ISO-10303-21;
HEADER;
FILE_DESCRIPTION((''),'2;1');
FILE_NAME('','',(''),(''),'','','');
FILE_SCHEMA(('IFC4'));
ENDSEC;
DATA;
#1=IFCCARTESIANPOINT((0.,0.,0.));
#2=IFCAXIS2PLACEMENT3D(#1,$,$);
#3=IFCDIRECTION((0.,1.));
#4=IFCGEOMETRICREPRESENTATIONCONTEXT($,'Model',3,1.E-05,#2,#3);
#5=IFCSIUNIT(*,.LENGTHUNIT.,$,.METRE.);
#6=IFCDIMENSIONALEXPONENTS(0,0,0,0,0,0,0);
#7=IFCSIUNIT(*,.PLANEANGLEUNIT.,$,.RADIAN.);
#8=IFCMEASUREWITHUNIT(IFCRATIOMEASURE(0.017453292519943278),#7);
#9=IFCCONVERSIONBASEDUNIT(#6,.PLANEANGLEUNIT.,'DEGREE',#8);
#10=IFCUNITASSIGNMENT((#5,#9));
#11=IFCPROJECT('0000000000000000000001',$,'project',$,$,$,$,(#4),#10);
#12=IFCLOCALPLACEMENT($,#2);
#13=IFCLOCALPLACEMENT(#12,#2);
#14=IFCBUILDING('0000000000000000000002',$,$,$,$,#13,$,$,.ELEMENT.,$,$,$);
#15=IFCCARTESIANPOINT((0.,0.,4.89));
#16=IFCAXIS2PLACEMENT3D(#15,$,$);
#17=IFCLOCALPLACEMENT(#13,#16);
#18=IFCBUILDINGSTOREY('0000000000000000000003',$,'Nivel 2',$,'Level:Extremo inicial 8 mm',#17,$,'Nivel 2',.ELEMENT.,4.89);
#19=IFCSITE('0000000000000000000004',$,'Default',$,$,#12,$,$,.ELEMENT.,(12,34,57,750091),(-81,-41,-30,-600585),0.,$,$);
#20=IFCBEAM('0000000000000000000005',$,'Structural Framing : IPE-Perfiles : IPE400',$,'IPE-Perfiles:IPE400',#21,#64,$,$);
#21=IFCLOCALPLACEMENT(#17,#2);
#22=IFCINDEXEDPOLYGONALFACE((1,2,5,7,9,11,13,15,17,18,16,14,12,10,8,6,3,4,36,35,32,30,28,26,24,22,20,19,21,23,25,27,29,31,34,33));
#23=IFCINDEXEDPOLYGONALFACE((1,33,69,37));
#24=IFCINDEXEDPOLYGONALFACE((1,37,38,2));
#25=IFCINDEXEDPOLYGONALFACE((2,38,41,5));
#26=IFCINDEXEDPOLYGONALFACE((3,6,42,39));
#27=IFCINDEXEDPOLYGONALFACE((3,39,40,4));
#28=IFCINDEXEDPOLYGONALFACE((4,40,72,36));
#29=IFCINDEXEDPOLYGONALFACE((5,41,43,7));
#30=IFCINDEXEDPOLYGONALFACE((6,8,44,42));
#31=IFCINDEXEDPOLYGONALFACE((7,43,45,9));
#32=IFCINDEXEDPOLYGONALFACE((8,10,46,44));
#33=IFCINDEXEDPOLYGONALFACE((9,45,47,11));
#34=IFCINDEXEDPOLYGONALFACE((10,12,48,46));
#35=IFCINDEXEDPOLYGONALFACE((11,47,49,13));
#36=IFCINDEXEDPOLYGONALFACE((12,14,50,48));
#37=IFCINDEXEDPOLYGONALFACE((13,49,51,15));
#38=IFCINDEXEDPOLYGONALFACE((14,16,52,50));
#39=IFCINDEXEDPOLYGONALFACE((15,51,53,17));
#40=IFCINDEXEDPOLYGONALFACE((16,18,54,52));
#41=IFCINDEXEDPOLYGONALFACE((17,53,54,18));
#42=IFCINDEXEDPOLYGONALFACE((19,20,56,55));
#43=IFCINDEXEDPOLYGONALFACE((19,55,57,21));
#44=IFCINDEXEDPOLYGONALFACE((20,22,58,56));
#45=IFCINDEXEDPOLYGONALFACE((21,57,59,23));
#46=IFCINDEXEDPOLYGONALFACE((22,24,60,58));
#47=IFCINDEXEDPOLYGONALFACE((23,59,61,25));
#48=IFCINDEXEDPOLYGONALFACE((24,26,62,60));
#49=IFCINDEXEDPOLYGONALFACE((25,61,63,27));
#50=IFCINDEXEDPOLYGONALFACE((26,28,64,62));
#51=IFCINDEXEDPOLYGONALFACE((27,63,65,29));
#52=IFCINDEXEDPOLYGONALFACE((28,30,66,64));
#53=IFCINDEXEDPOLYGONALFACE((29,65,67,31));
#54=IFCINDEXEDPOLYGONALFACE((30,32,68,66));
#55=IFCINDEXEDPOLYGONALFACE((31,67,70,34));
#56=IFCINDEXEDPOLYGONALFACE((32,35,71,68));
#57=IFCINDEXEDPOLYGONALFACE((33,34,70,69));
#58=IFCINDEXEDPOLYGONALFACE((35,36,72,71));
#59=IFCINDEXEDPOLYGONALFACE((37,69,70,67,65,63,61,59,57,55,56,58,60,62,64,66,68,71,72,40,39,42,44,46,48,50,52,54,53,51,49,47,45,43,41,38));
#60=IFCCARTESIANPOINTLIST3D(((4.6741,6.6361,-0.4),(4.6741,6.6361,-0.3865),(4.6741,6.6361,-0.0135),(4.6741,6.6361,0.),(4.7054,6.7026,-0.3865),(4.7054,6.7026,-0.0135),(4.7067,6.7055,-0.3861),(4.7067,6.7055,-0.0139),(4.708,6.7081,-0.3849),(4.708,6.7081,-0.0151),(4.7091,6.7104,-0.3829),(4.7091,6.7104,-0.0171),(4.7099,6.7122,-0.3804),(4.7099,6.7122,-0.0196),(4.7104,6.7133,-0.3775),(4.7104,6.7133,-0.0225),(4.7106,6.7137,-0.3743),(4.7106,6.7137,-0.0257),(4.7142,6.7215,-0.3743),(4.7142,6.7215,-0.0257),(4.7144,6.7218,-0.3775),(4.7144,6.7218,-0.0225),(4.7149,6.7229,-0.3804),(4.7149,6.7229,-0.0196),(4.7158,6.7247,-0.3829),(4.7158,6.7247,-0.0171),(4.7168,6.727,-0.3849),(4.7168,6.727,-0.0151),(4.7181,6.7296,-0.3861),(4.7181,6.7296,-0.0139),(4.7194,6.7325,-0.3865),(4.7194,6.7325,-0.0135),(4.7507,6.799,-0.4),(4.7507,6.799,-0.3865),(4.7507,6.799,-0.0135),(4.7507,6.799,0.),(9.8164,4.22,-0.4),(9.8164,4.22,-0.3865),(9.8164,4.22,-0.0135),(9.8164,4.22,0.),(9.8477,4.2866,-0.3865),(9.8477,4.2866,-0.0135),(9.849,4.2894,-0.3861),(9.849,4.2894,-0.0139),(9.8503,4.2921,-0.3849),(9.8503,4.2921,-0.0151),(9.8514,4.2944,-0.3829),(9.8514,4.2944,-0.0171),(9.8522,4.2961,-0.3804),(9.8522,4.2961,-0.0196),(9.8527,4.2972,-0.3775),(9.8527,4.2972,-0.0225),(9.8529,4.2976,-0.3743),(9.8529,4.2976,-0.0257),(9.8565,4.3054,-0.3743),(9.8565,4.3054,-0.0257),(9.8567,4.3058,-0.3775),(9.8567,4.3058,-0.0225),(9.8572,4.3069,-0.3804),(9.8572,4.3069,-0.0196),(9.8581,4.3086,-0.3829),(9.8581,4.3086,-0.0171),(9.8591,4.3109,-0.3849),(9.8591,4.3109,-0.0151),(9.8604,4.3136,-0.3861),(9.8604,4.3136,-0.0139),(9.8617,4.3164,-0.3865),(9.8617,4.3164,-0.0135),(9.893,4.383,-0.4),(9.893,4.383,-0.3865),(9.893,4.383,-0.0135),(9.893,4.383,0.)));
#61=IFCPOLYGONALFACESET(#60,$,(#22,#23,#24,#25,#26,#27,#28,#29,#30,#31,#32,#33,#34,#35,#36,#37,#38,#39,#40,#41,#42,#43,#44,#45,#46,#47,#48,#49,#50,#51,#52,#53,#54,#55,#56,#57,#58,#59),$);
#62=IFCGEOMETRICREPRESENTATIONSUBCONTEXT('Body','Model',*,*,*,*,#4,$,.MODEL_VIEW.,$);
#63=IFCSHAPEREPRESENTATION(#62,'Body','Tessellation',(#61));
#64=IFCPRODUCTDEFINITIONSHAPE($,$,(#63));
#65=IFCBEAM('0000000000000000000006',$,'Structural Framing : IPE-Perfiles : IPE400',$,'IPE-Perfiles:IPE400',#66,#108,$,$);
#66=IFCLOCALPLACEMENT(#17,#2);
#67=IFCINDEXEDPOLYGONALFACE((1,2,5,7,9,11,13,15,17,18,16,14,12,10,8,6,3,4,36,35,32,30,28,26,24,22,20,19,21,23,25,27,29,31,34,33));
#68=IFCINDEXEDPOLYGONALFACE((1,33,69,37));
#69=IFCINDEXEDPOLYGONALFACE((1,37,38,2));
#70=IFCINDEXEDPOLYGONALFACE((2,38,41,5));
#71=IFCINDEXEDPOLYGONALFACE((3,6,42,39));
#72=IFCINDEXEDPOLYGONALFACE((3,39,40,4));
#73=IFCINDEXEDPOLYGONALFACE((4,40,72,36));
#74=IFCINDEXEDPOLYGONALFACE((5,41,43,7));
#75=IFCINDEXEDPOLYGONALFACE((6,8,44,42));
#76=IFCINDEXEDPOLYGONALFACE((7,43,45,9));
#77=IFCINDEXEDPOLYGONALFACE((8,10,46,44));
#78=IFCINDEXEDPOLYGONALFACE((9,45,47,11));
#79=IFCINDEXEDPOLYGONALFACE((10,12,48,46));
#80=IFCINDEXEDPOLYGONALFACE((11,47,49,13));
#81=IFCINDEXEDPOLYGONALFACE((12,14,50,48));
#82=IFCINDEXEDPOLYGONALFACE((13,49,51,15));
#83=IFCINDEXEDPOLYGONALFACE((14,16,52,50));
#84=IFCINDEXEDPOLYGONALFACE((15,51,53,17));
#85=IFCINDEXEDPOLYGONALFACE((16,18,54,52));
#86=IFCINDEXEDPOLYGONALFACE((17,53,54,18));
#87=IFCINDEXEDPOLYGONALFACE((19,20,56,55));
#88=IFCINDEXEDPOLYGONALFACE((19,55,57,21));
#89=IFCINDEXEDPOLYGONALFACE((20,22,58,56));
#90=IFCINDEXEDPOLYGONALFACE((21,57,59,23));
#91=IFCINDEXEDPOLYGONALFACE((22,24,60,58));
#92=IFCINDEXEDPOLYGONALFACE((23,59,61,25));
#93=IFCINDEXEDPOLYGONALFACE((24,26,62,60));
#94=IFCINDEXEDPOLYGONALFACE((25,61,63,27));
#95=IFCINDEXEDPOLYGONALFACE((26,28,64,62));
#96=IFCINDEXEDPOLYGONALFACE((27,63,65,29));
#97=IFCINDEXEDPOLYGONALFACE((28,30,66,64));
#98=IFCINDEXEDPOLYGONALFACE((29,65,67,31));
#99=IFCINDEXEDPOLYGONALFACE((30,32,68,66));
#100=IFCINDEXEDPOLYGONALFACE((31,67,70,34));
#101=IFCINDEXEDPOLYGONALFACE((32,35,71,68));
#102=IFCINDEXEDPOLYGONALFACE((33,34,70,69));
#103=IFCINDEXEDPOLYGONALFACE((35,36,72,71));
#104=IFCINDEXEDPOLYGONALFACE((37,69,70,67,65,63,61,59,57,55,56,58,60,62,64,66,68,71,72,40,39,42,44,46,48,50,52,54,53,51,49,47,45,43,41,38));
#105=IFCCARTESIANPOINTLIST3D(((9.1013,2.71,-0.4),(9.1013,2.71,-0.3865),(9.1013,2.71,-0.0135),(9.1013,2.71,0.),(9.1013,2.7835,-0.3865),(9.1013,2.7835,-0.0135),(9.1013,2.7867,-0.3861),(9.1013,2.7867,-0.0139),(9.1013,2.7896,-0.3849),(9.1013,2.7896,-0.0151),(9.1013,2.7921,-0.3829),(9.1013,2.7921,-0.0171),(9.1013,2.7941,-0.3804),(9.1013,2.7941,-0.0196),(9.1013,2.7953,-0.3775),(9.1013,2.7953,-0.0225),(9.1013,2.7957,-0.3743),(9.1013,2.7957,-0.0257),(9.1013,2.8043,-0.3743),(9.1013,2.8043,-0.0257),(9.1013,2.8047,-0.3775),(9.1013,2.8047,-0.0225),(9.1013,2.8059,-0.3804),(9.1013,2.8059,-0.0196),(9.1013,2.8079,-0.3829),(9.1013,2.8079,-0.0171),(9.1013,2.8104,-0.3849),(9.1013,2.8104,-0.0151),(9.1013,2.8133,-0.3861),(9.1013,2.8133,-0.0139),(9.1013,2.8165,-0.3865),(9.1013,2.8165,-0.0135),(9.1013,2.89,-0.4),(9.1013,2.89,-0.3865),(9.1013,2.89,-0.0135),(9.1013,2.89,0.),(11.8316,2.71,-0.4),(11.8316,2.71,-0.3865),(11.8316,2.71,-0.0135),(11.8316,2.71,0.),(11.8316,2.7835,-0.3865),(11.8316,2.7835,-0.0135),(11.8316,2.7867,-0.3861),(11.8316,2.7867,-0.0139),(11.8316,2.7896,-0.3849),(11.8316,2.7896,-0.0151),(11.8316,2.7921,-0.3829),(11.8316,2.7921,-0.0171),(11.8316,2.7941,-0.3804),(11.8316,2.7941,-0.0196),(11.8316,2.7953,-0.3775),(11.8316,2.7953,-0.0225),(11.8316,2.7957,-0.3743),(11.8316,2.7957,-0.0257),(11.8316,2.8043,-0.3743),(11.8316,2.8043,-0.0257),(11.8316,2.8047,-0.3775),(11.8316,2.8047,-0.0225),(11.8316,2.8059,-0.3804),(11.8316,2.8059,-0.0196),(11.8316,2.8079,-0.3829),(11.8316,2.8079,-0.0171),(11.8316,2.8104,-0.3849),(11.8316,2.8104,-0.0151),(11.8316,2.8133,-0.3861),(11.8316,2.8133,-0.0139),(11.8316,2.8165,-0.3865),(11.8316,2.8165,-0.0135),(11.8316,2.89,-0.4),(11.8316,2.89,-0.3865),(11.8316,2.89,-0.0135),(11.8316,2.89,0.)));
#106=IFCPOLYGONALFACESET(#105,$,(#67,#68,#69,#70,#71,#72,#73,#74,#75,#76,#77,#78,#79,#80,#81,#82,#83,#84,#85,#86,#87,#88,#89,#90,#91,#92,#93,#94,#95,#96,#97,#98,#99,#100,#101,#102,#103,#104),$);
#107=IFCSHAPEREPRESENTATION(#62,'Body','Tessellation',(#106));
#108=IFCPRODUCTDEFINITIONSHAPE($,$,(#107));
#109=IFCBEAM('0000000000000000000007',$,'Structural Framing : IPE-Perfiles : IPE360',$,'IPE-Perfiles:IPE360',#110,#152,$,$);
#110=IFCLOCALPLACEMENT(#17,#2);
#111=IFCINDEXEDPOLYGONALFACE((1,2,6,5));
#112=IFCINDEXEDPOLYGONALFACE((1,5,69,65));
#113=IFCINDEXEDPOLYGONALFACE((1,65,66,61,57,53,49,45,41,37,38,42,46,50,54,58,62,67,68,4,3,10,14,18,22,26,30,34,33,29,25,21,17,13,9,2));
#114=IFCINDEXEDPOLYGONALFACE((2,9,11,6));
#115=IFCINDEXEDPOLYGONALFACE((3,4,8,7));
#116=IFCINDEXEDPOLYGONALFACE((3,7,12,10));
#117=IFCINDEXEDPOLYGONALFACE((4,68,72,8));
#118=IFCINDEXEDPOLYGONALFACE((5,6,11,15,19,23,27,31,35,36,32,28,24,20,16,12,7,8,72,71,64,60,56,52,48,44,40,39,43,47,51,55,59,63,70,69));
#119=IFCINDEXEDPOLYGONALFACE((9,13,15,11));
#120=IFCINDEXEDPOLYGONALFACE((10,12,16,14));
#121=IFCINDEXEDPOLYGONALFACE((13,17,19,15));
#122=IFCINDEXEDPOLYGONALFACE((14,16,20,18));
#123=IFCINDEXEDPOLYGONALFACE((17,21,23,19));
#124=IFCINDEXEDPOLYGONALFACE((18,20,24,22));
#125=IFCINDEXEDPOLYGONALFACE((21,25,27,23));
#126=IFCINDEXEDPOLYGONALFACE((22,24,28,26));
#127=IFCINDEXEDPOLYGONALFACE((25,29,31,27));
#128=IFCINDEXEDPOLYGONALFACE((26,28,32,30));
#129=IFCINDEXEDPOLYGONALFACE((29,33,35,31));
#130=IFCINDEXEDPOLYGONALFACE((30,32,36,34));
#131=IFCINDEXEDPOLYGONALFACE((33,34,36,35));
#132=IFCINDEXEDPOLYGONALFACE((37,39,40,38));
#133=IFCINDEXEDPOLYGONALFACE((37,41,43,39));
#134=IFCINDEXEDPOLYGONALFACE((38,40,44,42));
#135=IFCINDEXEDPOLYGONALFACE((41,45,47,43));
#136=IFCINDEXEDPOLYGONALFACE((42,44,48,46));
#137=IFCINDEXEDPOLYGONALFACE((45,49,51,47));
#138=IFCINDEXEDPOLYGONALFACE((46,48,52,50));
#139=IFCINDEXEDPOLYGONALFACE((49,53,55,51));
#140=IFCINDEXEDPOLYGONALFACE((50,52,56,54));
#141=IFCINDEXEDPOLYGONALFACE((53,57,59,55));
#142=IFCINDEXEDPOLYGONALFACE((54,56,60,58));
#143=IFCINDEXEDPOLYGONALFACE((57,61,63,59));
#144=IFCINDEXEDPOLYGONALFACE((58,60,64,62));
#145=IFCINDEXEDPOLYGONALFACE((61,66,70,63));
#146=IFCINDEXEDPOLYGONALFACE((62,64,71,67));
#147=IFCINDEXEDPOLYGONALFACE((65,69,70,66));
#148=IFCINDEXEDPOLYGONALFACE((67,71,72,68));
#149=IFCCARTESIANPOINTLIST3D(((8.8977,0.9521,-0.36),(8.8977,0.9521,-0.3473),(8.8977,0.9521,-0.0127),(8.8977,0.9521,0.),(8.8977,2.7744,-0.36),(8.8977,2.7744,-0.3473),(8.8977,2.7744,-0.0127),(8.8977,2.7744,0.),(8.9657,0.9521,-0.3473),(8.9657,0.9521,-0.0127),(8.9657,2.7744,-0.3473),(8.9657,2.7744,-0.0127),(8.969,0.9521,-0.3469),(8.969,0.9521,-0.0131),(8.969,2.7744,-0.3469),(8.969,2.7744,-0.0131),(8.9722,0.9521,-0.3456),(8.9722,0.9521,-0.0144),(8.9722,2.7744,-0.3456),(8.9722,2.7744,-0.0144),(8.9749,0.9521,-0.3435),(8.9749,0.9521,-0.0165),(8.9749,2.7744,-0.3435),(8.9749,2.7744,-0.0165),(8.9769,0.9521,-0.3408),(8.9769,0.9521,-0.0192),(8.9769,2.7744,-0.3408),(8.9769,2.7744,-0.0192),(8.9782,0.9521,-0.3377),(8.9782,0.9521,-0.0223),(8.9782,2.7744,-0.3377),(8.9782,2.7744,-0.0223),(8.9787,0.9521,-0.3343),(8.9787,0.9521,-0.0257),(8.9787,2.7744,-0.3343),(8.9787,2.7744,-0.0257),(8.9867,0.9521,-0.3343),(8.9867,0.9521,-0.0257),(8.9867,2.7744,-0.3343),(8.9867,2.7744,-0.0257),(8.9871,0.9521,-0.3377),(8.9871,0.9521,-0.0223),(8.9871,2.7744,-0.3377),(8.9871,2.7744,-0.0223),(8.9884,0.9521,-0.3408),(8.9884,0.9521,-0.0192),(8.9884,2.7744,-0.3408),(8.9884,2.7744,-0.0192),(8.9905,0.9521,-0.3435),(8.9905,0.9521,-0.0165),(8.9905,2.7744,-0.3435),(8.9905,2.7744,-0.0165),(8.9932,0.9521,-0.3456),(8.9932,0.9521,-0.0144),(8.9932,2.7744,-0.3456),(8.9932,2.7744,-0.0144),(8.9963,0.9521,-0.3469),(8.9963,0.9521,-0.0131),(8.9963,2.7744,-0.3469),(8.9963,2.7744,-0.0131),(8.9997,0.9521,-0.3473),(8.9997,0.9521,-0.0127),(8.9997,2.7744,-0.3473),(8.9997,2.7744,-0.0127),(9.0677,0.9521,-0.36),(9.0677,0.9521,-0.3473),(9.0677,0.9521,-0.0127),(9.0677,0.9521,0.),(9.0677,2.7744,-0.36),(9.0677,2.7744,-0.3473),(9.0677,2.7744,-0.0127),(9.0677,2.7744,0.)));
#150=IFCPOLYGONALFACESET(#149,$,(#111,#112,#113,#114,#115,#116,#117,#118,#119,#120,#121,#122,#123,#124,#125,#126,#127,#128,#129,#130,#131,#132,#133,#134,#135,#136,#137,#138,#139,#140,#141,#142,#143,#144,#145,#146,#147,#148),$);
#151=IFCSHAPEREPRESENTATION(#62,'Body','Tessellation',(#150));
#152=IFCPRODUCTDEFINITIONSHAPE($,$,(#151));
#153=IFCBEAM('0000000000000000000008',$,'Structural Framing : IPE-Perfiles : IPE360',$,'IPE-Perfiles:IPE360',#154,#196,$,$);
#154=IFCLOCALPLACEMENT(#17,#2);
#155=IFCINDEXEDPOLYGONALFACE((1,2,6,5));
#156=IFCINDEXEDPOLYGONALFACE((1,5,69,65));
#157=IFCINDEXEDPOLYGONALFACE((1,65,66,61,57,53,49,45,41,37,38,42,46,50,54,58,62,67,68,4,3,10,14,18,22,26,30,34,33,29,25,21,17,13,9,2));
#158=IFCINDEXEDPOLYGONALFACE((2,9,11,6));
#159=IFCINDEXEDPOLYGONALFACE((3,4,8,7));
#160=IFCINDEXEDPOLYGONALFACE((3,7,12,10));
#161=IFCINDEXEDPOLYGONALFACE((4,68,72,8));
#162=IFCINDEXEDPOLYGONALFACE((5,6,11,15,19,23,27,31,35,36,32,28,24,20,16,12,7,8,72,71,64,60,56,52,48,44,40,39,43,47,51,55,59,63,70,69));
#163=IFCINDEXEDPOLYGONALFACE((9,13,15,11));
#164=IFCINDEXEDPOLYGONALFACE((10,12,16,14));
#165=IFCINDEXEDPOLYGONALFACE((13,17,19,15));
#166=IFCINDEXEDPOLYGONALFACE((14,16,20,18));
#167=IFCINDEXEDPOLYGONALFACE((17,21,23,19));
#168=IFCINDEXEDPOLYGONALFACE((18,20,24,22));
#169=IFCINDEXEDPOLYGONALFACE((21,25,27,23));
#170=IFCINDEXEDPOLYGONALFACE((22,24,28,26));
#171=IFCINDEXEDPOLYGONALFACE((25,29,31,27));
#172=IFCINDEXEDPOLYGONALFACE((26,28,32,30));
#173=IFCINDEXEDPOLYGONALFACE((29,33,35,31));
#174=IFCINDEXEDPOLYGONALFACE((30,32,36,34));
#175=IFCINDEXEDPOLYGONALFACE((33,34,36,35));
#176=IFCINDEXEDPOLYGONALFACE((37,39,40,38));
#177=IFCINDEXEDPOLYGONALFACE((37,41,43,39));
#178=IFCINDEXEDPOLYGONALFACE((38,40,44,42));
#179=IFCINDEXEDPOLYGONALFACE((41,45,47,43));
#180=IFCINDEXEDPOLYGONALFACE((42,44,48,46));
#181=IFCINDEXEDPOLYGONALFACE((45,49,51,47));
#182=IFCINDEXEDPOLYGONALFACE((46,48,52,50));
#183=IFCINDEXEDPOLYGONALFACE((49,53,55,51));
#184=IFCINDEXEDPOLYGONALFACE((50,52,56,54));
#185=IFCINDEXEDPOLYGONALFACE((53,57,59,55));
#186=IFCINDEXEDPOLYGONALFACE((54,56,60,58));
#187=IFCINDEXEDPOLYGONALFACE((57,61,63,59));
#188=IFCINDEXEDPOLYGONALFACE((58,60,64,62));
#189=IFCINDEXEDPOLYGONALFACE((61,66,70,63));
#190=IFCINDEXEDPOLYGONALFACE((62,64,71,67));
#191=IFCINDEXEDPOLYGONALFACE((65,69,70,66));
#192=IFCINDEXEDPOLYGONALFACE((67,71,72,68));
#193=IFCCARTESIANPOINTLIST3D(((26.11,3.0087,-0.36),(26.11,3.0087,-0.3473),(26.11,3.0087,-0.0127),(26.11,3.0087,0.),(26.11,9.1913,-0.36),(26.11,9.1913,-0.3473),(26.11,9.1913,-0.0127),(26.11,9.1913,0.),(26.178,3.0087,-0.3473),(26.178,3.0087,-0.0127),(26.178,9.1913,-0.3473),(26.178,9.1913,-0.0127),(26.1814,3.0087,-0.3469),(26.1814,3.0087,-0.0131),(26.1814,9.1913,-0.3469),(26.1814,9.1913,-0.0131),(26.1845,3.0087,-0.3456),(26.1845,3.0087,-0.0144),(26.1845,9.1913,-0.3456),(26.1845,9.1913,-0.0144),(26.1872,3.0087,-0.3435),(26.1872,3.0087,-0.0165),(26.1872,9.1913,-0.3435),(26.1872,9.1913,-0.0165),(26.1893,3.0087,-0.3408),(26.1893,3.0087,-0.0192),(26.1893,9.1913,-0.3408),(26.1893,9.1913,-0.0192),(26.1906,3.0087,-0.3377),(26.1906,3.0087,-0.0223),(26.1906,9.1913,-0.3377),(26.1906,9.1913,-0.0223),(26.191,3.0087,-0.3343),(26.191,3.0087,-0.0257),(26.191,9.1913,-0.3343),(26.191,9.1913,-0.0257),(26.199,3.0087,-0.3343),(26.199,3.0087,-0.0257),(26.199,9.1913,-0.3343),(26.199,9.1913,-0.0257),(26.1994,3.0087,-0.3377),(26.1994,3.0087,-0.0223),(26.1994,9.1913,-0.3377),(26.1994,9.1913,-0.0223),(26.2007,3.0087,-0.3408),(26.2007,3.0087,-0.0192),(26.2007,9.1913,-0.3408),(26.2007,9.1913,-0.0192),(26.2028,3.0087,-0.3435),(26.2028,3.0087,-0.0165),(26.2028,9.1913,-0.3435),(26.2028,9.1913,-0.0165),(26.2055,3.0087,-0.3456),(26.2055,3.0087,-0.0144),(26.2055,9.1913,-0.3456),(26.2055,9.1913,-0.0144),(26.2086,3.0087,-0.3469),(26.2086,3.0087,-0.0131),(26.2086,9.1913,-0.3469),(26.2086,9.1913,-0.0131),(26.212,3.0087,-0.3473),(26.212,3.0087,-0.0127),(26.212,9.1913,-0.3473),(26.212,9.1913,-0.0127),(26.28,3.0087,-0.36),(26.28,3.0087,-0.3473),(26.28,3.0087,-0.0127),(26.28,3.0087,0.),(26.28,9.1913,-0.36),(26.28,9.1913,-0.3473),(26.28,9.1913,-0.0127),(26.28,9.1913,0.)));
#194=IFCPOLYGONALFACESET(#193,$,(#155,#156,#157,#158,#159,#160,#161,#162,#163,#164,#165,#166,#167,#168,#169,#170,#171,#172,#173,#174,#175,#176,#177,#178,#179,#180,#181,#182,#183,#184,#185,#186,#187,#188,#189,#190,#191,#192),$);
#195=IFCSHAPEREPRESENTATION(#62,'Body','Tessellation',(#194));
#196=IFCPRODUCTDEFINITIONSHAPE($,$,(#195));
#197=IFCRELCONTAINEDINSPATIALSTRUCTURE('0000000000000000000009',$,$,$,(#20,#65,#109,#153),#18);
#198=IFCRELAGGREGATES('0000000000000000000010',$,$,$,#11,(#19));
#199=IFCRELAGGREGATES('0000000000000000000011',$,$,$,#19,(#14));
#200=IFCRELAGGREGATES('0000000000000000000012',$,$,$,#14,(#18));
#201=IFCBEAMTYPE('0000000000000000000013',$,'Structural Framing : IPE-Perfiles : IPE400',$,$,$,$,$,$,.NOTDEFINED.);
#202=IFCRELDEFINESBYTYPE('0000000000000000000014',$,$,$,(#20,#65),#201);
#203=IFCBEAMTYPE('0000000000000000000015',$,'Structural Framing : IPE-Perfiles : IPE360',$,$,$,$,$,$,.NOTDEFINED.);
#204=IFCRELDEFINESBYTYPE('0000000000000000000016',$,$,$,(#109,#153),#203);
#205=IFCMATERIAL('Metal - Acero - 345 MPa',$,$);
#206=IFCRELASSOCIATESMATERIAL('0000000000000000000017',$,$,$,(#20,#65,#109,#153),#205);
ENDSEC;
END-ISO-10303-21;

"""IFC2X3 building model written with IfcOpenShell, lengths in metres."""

from ifc_helpers import new_model, entity, si_unit, converted_unit, direction, frame, frame_2d, origin, place, context, subcontext, project, spatial, i_section, extrude, material, type_object, element, save


model = new_model("IFC2X3")

# Units and contexts
model_context = context("Model", 3, precision=1e-05, world=origin(), true_north=direction((0.0, 1.0)))
body_context = subcontext(model_context, "Body", "Model", "MODEL_VIEW")
ifc_project = project(units=[si_unit("LENGTHUNIT", "METRE"), converted_unit("PLANEANGLEUNIT", "DEGREE", entity("IfcRatioMeasure", 0.017453292519943278), si_unit("PLANEANGLEUNIT", "RADIAN"), dimensions=[0, 0, 0, 0, 0, 0, 0])], contexts=[model_context])

# Site, building, storey
site_placement = place(None, origin())
site = spatial("IfcSite", under=ifc_project, at=site_placement, Name="Default", CompositionType="ELEMENT", RefLatitude=(12, 34, 57, 750091), RefLongitude=(-81, -41, -30, -600585), RefElevation=0.0)
building_placement = place(site_placement, origin())
building = spatial("IfcBuilding", under=site, at=building_placement, CompositionType="ELEMENT")
storey_placement = place(building_placement, frame((0.0, 0.0, 4.89)))
storey = spatial("IfcBuildingStorey", under=building, at=storey_placement, Name="Nivel 2", ObjectType="Level:Extremo inicial 8 mm", LongName="Nivel 2", CompositionType="ELEMENT", Elevation=4.89)

# Shared definitions
ifc_material_1 = material(Name="Metal - Acero - 345 MPa")

# Beams
beam_type_1 = type_object("IfcBeamType", Name="Structural Framing : IPE-Perfiles : IPE400", PredefinedType="NOTDEFINED")
beam_1_placement = place(storey_placement, frame((9.8671, 4.2957, 0.0), z_axis=(0.0, 0.0, 1.0), x_axis=(-0.905079, 0.425243, 0.0)))
element("IfcBeam", 1, at=beam_1_placement, inside=storey, type_object=beam_type_1, material=ifc_material_1, Name="Structural Framing : IPE-Perfiles : IPE400", ObjectType="IPE-Perfiles:IPE400", context=body_context, shape_type="SweptSolid", body=[
    extrude(i_section(OverallWidth=0.18, OverallDepth=0.4, WebThickness=0.0086, FlangeThickness=0.0135, FilletRadius=0.0122, at=frame_2d((0.0, 0.0), x_axis=(0.0, 1.0))), frame((0.0137, 0.0, -0.2), z_axis=(1.0, 0.0, 0.0), x_axis=(0.0, 0.0, -1.0)), (0.0, 0.0, 1.0), 5.6816),
])
beam_2_placement = place(storey_placement, frame((9.0882, 2.8, 0.0)))
element("IfcBeam", 2, at=beam_2_placement, inside=storey, type_object=beam_type_1, material=ifc_material_1, Name="Structural Framing : IPE-Perfiles : IPE400", ObjectType="IPE-Perfiles:IPE400", context=body_context, shape_type="SweptSolid", body=[
    extrude(i_section(OverallWidth=0.18, OverallDepth=0.4, WebThickness=0.0086, FlangeThickness=0.0135, FilletRadius=0.0122, at=frame_2d((0.0, 0.0), x_axis=(0.0, 1.0))), frame((0.013, 0.0, -0.2), z_axis=(1.0, 0.0, 0.0), x_axis=(0.0, 0.0, -1.0)), (0.0, 0.0, 1.0), 2.7303),
])
beam_type_2 = type_object("IfcBeamType", Name="Structural Framing : IPE-Perfiles : IPE360", PredefinedType="NOTDEFINED")
beam_3_placement = place(storey_placement, frame((8.9827, 1.02, 0.0), z_axis=(0.0, 0.0, 1.0), x_axis=(0.0, 1.0, 0.0)))
element("IfcBeam", 3, at=beam_3_placement, inside=storey, type_object=beam_type_2, material=ifc_material_1, Name="Structural Framing : IPE-Perfiles : IPE360", ObjectType="IPE-Perfiles:IPE360", context=body_context, shape_type="SweptSolid", body=[
    extrude(i_section(OverallWidth=0.17, OverallDepth=0.36, WebThickness=0.008, FlangeThickness=0.0127, FilletRadius=0.013, at=frame_2d((0.0, 0.0), x_axis=(0.0, 1.0))), frame((-0.0679, 0.0, -0.18), z_axis=(1.0, 0.0, 0.0), x_axis=(0.0, 0.0, -1.0)), (0.0, 0.0, 1.0), 1.8223),
])
beam_4_placement = place(storey_placement, frame((26.195, 2.995, 0.0), z_axis=(0.0, 0.0, 1.0), x_axis=(0.0, 1.0, 0.0)))
element("IfcBeam", 4, at=beam_4_placement, inside=storey, type_object=beam_type_2, material=ifc_material_1, Name="Structural Framing : IPE-Perfiles : IPE360", ObjectType="IPE-Perfiles:IPE360", context=body_context, shape_type="SweptSolid", body=[
    extrude(i_section(OverallWidth=0.17, OverallDepth=0.36, WebThickness=0.008, FlangeThickness=0.0127, FilletRadius=0.013, at=frame_2d((0.0, 0.0), x_axis=(0.0, 1.0))), frame((0.0137, 0.0, -0.18), z_axis=(1.0, 0.0, 0.0), x_axis=(0.0, 0.0, -1.0)), (0.0, 0.0, 1.0), 6.1826),
])

save(model, "model.ifc")
